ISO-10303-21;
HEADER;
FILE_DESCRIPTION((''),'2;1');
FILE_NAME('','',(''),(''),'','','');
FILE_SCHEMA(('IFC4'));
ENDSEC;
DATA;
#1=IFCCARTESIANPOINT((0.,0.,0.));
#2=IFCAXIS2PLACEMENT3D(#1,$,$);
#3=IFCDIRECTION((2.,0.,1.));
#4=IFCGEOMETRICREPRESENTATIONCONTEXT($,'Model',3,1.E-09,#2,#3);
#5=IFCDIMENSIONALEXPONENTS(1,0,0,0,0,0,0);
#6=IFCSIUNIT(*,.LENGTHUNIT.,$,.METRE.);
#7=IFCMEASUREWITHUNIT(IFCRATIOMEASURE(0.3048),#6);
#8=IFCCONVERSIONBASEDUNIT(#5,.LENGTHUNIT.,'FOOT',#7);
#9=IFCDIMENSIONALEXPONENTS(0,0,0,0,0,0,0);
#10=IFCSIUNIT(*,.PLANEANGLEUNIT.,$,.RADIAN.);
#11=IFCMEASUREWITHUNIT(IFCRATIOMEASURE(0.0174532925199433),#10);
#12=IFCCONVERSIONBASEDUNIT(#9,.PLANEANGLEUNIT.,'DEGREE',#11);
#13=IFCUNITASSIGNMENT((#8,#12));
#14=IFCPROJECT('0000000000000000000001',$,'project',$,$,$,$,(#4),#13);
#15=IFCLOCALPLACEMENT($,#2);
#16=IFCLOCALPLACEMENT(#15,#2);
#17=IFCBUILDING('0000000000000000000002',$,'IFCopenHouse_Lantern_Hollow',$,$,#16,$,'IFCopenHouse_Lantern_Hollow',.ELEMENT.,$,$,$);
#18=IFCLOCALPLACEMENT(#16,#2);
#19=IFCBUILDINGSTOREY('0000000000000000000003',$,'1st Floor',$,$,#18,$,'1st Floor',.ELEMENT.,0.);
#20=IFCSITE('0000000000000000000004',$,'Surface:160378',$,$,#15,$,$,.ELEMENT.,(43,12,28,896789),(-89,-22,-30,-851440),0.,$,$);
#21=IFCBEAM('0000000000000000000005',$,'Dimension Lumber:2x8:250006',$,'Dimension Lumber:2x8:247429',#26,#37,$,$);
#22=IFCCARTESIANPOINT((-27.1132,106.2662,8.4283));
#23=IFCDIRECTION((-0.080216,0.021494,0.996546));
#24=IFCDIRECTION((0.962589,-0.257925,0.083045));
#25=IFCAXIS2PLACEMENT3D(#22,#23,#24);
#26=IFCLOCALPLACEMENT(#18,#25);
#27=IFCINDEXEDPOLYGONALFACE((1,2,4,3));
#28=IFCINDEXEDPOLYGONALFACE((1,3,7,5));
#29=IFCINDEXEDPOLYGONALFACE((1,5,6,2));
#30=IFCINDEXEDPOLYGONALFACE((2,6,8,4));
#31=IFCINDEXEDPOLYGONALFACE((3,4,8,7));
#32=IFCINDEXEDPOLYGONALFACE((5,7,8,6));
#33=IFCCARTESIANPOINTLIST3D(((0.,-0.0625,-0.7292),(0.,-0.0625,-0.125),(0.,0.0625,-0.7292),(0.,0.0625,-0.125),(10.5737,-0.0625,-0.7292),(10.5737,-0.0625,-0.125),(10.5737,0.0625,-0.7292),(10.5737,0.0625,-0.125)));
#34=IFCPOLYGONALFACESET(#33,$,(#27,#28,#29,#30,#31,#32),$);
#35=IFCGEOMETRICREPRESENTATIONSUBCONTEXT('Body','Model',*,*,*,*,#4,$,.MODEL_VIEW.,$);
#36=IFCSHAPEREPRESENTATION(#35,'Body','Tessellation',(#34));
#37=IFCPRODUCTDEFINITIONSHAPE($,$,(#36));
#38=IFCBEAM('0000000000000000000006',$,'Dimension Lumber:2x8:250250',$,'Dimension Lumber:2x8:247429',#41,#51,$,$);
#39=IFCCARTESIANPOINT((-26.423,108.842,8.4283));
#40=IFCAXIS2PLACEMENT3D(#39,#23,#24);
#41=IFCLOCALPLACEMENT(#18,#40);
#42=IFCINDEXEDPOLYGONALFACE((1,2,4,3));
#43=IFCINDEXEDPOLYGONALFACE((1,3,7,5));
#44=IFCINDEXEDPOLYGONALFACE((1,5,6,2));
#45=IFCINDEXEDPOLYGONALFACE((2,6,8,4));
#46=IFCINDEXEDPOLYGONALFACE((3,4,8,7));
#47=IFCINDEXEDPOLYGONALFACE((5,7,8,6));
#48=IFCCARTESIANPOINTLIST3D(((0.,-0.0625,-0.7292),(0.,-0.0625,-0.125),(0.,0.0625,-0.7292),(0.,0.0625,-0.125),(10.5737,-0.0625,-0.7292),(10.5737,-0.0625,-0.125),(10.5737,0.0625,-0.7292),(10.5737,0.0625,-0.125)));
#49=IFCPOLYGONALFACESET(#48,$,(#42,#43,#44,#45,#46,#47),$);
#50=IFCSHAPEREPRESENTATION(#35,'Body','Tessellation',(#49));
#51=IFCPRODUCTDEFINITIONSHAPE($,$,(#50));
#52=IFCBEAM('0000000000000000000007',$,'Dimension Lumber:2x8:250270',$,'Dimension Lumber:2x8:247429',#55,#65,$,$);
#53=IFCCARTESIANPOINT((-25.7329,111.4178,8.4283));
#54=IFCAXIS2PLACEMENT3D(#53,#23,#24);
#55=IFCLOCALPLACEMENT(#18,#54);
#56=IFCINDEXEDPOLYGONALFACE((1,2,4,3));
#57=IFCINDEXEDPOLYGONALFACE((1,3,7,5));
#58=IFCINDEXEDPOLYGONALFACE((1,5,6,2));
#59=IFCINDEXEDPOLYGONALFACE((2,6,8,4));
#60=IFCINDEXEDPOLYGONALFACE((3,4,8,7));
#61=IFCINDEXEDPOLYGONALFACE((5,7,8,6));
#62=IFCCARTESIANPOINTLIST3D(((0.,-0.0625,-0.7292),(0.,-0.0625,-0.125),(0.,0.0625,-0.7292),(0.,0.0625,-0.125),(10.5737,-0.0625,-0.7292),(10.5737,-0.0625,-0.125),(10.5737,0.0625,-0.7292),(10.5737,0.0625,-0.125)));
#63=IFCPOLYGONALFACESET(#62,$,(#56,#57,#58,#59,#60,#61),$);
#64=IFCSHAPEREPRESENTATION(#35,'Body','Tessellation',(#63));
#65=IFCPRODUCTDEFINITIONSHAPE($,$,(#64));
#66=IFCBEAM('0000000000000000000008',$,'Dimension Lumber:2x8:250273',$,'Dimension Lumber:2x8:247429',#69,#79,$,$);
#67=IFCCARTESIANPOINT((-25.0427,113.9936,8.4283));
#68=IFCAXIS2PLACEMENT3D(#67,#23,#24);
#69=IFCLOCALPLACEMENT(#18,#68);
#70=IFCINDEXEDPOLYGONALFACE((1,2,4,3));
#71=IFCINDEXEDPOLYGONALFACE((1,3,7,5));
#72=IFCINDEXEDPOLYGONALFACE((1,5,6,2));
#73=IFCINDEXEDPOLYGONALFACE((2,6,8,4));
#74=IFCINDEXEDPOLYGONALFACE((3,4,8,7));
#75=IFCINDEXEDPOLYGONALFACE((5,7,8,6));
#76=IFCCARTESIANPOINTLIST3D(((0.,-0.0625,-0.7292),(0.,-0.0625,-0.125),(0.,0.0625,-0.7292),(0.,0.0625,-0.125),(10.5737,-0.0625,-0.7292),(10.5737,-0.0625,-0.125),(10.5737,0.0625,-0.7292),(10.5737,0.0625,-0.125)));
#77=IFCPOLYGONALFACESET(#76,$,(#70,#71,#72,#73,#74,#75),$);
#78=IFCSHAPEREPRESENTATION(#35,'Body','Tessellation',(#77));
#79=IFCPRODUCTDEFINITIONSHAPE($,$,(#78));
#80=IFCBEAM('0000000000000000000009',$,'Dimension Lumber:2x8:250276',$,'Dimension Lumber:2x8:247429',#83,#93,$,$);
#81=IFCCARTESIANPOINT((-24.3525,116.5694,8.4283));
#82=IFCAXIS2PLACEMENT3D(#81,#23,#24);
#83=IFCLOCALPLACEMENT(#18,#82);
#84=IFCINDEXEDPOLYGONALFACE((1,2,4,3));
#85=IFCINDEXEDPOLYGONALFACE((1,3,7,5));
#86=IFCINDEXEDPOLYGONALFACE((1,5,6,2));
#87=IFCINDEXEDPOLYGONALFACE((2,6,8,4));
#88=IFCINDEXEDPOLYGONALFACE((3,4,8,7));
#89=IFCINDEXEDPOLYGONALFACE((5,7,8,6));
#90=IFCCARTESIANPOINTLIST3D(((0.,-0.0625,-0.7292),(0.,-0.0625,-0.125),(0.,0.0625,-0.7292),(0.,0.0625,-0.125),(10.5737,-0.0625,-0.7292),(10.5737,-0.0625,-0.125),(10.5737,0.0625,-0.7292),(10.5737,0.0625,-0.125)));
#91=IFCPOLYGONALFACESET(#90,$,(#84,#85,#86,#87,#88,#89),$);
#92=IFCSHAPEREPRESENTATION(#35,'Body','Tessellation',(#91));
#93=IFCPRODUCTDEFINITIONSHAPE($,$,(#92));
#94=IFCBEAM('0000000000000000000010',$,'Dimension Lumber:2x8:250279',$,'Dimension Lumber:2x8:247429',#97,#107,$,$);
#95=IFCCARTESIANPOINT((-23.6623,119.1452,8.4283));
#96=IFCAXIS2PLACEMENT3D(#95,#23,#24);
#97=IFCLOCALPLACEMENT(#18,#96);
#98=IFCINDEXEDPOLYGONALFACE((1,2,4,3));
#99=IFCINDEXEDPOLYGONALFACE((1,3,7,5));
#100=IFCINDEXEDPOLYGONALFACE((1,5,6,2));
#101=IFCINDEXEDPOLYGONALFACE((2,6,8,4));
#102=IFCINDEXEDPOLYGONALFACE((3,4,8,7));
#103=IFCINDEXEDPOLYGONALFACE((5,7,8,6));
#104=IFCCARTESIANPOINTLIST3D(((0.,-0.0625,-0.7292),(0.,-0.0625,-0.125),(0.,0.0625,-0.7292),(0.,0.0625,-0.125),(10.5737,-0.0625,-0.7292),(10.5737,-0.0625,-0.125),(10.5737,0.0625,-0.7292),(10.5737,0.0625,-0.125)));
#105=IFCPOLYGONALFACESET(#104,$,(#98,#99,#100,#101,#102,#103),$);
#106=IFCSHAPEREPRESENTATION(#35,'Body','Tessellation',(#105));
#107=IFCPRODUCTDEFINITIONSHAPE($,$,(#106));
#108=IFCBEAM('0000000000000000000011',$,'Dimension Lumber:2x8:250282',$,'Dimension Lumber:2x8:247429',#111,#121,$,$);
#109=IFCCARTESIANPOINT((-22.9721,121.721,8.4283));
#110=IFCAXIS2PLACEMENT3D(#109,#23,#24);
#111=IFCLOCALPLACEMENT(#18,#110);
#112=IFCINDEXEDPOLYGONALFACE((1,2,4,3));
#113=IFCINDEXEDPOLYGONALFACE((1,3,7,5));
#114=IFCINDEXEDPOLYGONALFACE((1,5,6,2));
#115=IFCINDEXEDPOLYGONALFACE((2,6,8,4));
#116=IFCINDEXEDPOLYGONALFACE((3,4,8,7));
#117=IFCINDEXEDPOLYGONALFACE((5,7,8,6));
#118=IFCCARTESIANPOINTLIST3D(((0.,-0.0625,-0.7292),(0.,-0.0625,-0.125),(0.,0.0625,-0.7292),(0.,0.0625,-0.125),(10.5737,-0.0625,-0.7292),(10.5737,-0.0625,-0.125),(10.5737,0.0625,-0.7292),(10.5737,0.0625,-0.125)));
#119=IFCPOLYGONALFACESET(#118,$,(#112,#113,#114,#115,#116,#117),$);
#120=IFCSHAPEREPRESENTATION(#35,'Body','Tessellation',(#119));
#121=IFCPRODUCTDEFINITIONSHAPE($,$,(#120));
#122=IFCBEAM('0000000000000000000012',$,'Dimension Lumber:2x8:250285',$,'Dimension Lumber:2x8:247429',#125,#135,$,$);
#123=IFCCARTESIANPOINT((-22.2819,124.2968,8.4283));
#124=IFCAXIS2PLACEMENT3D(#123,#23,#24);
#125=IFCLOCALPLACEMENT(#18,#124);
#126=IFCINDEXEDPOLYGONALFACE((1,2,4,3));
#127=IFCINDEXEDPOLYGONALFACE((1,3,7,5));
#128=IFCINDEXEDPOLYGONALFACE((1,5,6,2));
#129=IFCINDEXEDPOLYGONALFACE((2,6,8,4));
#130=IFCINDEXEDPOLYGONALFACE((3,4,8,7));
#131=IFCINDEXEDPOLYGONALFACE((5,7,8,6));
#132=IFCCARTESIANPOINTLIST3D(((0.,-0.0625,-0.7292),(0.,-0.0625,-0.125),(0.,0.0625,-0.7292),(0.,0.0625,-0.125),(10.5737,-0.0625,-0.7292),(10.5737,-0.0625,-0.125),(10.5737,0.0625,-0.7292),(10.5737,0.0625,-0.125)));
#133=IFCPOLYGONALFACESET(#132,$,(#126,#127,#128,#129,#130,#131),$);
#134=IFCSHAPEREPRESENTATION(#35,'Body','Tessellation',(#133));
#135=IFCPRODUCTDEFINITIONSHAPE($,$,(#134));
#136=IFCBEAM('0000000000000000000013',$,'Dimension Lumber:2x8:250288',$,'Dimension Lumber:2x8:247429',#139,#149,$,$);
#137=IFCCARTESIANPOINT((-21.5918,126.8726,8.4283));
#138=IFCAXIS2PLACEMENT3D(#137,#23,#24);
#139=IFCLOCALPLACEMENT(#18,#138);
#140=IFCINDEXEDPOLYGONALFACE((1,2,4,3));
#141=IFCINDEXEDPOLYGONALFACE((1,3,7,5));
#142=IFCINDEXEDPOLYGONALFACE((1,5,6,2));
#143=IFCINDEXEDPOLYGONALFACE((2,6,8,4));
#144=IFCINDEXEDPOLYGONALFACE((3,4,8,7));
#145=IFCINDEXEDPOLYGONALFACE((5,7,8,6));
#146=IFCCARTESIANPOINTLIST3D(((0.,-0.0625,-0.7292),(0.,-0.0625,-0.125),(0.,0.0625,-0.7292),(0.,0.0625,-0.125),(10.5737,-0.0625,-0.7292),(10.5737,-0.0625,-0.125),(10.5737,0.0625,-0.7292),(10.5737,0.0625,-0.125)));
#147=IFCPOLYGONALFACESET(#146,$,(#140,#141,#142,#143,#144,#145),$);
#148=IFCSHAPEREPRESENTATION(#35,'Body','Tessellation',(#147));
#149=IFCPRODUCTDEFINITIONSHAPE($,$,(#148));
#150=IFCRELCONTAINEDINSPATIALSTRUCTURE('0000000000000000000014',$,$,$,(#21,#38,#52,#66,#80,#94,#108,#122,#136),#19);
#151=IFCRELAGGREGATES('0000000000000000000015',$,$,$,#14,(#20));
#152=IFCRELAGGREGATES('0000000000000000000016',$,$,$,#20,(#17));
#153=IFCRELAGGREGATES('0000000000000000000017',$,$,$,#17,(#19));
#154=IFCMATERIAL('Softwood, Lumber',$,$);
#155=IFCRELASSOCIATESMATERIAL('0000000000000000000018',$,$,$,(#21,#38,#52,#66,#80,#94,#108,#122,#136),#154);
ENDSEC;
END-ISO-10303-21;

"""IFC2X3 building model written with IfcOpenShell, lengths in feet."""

from ifc_helpers import new_model, entity, si_unit, converted_unit, direction, frame, frame_2d, origin, place, context, subcontext, project, spatial, rectangle, extrude, material, element, save


model = new_model("IFC2X3")

# Units and contexts
model_context = context("Model", 3, precision=1e-09, world=origin(), true_north=direction((2.0, 0.0, 1.0)))
body_context = subcontext(model_context, "Body", "Model", "MODEL_VIEW")
ifc_project = project(units=[converted_unit("LENGTHUNIT", "FOOT", entity("IfcRatioMeasure", 0.3048), si_unit("LENGTHUNIT", "METRE"), dimensions=[1, 0, 0, 0, 0, 0, 0]), converted_unit("PLANEANGLEUNIT", "DEGREE", entity("IfcRatioMeasure", 0.0174532925199433), si_unit("PLANEANGLEUNIT", "RADIAN"), dimensions=[0, 0, 0, 0, 0, 0, 0])], contexts=[model_context])

# Site, building, storey
site_placement = place(None, origin())
site = spatial("IfcSite", under=ifc_project, at=site_placement, Name="Surface:160378", CompositionType="ELEMENT", RefLatitude=(43, 12, 28, 896789), RefLongitude=(-89, -22, -30, -851440), RefElevation=0.0)
building_placement = place(site_placement, origin())
building = spatial("IfcBuilding", under=site, at=building_placement, Name="IFCopenHouse_Lantern_Hollow", LongName="IFCopenHouse_Lantern_Hollow", CompositionType="ELEMENT")
storey_placement = place(building_placement, origin())
storey = spatial("IfcBuildingStorey", under=building, at=storey_placement, Name="1st Floor", LongName="1st Floor", CompositionType="ELEMENT", Elevation=0.0)

# Beams
ifc_material_1 = material(Name="Softwood, Lumber")
beam_1_placement = place(storey_placement, frame((-27.1132, 106.2662, 8.4283), z_axis=(-0.080216, 0.021494, 0.996546), x_axis=(0.962589, -0.257925, 0.083045)))
element("IfcBeam", 1, at=beam_1_placement, inside=storey, material=ifc_material_1, Name="Dimension Lumber:2x8:250006", ObjectType="Dimension Lumber:2x8:247429", context=body_context, shape_type="SweptSolid", body=[
    extrude(rectangle(XDim=0.6042, YDim=0.125, at=frame_2d((0.0, 0.0), x_axis=(1.0, 0.0))), frame((0.0, 0.0, -0.4271), z_axis=(1.0, 0.0, 0.0), x_axis=(0.0, 0.0, -1.0)), (0.0, 0.0, 1.0), 10.5737),
])
beam_2_placement = place(storey_placement, frame((-26.423, 108.842, 8.4283), z_axis=(-0.080216, 0.021494, 0.996546), x_axis=(0.962589, -0.257925, 0.083045)))
element("IfcBeam", 2, at=beam_2_placement, inside=storey, material=ifc_material_1, Name="Dimension Lumber:2x8:250250", ObjectType="Dimension Lumber:2x8:247429", context=body_context, shape_type="SweptSolid", body=[
    extrude(rectangle(XDim=0.6042, YDim=0.125, at=frame_2d((0.0, 0.0), x_axis=(1.0, 0.0))), frame((0.0, 0.0, -0.4271), z_axis=(1.0, 0.0, 0.0), x_axis=(0.0, 0.0, -1.0)), (0.0, 0.0, 1.0), 10.5737),
])
beam_3_placement = place(storey_placement, frame((-25.7329, 111.4178, 8.4283), z_axis=(-0.080216, 0.021494, 0.996546), x_axis=(0.962589, -0.257925, 0.083045)))
element("IfcBeam", 3, at=beam_3_placement, inside=storey, material=ifc_material_1, Name="Dimension Lumber:2x8:250270", ObjectType="Dimension Lumber:2x8:247429", context=body_context, shape_type="SweptSolid", body=[
    extrude(rectangle(XDim=0.6042, YDim=0.125, at=frame_2d((0.0, 0.0), x_axis=(1.0, 0.0))), frame((0.0, 0.0, -0.4271), z_axis=(1.0, 0.0, 0.0), x_axis=(0.0, 0.0, -1.0)), (0.0, 0.0, 1.0), 10.5737),
])
beam_4_placement = place(storey_placement, frame((-25.0427, 113.9936, 8.4283), z_axis=(-0.080216, 0.021494, 0.996546), x_axis=(0.962589, -0.257925, 0.083045)))
element("IfcBeam", 4, at=beam_4_placement, inside=storey, material=ifc_material_1, Name="Dimension Lumber:2x8:250273", ObjectType="Dimension Lumber:2x8:247429", context=body_context, shape_type="SweptSolid", body=[
    extrude(rectangle(XDim=0.6042, YDim=0.125, at=frame_2d((0.0, 0.0), x_axis=(1.0, 0.0))), frame((0.0, 0.0, -0.4271), z_axis=(1.0, 0.0, 0.0), x_axis=(0.0, 0.0, -1.0)), (0.0, 0.0, 1.0), 10.5737),
])
beam_5_placement = place(storey_placement, frame((-24.3525, 116.5694, 8.4283), z_axis=(-0.080216, 0.021494, 0.996546), x_axis=(0.962589, -0.257925, 0.083045)))
element("IfcBeam", 5, at=beam_5_placement, inside=storey, material=ifc_material_1, Name="Dimension Lumber:2x8:250276", ObjectType="Dimension Lumber:2x8:247429", context=body_context, shape_type="SweptSolid", body=[
    extrude(rectangle(XDim=0.6042, YDim=0.125, at=frame_2d((0.0, 0.0), x_axis=(1.0, 0.0))), frame((0.0, 0.0, -0.4271), z_axis=(1.0, 0.0, 0.0), x_axis=(0.0, 0.0, -1.0)), (0.0, 0.0, 1.0), 10.5737),
])
beam_6_placement = place(storey_placement, frame((-23.6623, 119.1452, 8.4283), z_axis=(-0.080216, 0.021494, 0.996546), x_axis=(0.962589, -0.257925, 0.083045)))
element("IfcBeam", 6, at=beam_6_placement, inside=storey, material=ifc_material_1, Name="Dimension Lumber:2x8:250279", ObjectType="Dimension Lumber:2x8:247429", context=body_context, shape_type="SweptSolid", body=[
    extrude(rectangle(XDim=0.6042, YDim=0.125, at=frame_2d((0.0, 0.0), x_axis=(1.0, 0.0))), frame((0.0, 0.0, -0.4271), z_axis=(1.0, 0.0, 0.0), x_axis=(0.0, 0.0, -1.0)), (0.0, 0.0, 1.0), 10.5737),
])
beam_7_placement = place(storey_placement, frame((-22.9721, 121.721, 8.4283), z_axis=(-0.080216, 0.021494, 0.996546), x_axis=(0.962589, -0.257925, 0.083045)))
element("IfcBeam", 7, at=beam_7_placement, inside=storey, material=ifc_material_1, Name="Dimension Lumber:2x8:250282", ObjectType="Dimension Lumber:2x8:247429", context=body_context, shape_type="SweptSolid", body=[
    extrude(rectangle(XDim=0.6042, YDim=0.125, at=frame_2d((0.0, 0.0), x_axis=(1.0, 0.0))), frame((0.0, 0.0, -0.4271), z_axis=(1.0, 0.0, 0.0), x_axis=(0.0, 0.0, -1.0)), (0.0, 0.0, 1.0), 10.5737),
])
beam_8_placement = place(storey_placement, frame((-22.2819, 124.2968, 8.4283), z_axis=(-0.080216, 0.021494, 0.996546), x_axis=(0.962589, -0.257925, 0.083045)))
element("IfcBeam", 8, at=beam_8_placement, inside=storey, material=ifc_material_1, Name="Dimension Lumber:2x8:250285", ObjectType="Dimension Lumber:2x8:247429", context=body_context, shape_type="SweptSolid", body=[
    extrude(rectangle(XDim=0.6042, YDim=0.125, at=frame_2d((0.0, 0.0), x_axis=(1.0, 0.0))), frame((0.0, 0.0, -0.4271), z_axis=(1.0, 0.0, 0.0), x_axis=(0.0, 0.0, -1.0)), (0.0, 0.0, 1.0), 10.5737),
])
beam_9_placement = place(storey_placement, frame((-21.5918, 126.8726, 8.4283), z_axis=(-0.080216, 0.021494, 0.996546), x_axis=(0.962589, -0.257925, 0.083045)))
element("IfcBeam", 9, at=beam_9_placement, inside=storey, material=ifc_material_1, Name="Dimension Lumber:2x8:250288", ObjectType="Dimension Lumber:2x8:247429", context=body_context, shape_type="SweptSolid", body=[
    extrude(rectangle(XDim=0.6042, YDim=0.125, at=frame_2d((0.0, 0.0), x_axis=(1.0, 0.0))), frame((0.0, 0.0, -0.4271), z_axis=(1.0, 0.0, 0.0), x_axis=(0.0, 0.0, -1.0)), (0.0, 0.0, 1.0), 10.5737),
])

save(model, "model.ifc")
